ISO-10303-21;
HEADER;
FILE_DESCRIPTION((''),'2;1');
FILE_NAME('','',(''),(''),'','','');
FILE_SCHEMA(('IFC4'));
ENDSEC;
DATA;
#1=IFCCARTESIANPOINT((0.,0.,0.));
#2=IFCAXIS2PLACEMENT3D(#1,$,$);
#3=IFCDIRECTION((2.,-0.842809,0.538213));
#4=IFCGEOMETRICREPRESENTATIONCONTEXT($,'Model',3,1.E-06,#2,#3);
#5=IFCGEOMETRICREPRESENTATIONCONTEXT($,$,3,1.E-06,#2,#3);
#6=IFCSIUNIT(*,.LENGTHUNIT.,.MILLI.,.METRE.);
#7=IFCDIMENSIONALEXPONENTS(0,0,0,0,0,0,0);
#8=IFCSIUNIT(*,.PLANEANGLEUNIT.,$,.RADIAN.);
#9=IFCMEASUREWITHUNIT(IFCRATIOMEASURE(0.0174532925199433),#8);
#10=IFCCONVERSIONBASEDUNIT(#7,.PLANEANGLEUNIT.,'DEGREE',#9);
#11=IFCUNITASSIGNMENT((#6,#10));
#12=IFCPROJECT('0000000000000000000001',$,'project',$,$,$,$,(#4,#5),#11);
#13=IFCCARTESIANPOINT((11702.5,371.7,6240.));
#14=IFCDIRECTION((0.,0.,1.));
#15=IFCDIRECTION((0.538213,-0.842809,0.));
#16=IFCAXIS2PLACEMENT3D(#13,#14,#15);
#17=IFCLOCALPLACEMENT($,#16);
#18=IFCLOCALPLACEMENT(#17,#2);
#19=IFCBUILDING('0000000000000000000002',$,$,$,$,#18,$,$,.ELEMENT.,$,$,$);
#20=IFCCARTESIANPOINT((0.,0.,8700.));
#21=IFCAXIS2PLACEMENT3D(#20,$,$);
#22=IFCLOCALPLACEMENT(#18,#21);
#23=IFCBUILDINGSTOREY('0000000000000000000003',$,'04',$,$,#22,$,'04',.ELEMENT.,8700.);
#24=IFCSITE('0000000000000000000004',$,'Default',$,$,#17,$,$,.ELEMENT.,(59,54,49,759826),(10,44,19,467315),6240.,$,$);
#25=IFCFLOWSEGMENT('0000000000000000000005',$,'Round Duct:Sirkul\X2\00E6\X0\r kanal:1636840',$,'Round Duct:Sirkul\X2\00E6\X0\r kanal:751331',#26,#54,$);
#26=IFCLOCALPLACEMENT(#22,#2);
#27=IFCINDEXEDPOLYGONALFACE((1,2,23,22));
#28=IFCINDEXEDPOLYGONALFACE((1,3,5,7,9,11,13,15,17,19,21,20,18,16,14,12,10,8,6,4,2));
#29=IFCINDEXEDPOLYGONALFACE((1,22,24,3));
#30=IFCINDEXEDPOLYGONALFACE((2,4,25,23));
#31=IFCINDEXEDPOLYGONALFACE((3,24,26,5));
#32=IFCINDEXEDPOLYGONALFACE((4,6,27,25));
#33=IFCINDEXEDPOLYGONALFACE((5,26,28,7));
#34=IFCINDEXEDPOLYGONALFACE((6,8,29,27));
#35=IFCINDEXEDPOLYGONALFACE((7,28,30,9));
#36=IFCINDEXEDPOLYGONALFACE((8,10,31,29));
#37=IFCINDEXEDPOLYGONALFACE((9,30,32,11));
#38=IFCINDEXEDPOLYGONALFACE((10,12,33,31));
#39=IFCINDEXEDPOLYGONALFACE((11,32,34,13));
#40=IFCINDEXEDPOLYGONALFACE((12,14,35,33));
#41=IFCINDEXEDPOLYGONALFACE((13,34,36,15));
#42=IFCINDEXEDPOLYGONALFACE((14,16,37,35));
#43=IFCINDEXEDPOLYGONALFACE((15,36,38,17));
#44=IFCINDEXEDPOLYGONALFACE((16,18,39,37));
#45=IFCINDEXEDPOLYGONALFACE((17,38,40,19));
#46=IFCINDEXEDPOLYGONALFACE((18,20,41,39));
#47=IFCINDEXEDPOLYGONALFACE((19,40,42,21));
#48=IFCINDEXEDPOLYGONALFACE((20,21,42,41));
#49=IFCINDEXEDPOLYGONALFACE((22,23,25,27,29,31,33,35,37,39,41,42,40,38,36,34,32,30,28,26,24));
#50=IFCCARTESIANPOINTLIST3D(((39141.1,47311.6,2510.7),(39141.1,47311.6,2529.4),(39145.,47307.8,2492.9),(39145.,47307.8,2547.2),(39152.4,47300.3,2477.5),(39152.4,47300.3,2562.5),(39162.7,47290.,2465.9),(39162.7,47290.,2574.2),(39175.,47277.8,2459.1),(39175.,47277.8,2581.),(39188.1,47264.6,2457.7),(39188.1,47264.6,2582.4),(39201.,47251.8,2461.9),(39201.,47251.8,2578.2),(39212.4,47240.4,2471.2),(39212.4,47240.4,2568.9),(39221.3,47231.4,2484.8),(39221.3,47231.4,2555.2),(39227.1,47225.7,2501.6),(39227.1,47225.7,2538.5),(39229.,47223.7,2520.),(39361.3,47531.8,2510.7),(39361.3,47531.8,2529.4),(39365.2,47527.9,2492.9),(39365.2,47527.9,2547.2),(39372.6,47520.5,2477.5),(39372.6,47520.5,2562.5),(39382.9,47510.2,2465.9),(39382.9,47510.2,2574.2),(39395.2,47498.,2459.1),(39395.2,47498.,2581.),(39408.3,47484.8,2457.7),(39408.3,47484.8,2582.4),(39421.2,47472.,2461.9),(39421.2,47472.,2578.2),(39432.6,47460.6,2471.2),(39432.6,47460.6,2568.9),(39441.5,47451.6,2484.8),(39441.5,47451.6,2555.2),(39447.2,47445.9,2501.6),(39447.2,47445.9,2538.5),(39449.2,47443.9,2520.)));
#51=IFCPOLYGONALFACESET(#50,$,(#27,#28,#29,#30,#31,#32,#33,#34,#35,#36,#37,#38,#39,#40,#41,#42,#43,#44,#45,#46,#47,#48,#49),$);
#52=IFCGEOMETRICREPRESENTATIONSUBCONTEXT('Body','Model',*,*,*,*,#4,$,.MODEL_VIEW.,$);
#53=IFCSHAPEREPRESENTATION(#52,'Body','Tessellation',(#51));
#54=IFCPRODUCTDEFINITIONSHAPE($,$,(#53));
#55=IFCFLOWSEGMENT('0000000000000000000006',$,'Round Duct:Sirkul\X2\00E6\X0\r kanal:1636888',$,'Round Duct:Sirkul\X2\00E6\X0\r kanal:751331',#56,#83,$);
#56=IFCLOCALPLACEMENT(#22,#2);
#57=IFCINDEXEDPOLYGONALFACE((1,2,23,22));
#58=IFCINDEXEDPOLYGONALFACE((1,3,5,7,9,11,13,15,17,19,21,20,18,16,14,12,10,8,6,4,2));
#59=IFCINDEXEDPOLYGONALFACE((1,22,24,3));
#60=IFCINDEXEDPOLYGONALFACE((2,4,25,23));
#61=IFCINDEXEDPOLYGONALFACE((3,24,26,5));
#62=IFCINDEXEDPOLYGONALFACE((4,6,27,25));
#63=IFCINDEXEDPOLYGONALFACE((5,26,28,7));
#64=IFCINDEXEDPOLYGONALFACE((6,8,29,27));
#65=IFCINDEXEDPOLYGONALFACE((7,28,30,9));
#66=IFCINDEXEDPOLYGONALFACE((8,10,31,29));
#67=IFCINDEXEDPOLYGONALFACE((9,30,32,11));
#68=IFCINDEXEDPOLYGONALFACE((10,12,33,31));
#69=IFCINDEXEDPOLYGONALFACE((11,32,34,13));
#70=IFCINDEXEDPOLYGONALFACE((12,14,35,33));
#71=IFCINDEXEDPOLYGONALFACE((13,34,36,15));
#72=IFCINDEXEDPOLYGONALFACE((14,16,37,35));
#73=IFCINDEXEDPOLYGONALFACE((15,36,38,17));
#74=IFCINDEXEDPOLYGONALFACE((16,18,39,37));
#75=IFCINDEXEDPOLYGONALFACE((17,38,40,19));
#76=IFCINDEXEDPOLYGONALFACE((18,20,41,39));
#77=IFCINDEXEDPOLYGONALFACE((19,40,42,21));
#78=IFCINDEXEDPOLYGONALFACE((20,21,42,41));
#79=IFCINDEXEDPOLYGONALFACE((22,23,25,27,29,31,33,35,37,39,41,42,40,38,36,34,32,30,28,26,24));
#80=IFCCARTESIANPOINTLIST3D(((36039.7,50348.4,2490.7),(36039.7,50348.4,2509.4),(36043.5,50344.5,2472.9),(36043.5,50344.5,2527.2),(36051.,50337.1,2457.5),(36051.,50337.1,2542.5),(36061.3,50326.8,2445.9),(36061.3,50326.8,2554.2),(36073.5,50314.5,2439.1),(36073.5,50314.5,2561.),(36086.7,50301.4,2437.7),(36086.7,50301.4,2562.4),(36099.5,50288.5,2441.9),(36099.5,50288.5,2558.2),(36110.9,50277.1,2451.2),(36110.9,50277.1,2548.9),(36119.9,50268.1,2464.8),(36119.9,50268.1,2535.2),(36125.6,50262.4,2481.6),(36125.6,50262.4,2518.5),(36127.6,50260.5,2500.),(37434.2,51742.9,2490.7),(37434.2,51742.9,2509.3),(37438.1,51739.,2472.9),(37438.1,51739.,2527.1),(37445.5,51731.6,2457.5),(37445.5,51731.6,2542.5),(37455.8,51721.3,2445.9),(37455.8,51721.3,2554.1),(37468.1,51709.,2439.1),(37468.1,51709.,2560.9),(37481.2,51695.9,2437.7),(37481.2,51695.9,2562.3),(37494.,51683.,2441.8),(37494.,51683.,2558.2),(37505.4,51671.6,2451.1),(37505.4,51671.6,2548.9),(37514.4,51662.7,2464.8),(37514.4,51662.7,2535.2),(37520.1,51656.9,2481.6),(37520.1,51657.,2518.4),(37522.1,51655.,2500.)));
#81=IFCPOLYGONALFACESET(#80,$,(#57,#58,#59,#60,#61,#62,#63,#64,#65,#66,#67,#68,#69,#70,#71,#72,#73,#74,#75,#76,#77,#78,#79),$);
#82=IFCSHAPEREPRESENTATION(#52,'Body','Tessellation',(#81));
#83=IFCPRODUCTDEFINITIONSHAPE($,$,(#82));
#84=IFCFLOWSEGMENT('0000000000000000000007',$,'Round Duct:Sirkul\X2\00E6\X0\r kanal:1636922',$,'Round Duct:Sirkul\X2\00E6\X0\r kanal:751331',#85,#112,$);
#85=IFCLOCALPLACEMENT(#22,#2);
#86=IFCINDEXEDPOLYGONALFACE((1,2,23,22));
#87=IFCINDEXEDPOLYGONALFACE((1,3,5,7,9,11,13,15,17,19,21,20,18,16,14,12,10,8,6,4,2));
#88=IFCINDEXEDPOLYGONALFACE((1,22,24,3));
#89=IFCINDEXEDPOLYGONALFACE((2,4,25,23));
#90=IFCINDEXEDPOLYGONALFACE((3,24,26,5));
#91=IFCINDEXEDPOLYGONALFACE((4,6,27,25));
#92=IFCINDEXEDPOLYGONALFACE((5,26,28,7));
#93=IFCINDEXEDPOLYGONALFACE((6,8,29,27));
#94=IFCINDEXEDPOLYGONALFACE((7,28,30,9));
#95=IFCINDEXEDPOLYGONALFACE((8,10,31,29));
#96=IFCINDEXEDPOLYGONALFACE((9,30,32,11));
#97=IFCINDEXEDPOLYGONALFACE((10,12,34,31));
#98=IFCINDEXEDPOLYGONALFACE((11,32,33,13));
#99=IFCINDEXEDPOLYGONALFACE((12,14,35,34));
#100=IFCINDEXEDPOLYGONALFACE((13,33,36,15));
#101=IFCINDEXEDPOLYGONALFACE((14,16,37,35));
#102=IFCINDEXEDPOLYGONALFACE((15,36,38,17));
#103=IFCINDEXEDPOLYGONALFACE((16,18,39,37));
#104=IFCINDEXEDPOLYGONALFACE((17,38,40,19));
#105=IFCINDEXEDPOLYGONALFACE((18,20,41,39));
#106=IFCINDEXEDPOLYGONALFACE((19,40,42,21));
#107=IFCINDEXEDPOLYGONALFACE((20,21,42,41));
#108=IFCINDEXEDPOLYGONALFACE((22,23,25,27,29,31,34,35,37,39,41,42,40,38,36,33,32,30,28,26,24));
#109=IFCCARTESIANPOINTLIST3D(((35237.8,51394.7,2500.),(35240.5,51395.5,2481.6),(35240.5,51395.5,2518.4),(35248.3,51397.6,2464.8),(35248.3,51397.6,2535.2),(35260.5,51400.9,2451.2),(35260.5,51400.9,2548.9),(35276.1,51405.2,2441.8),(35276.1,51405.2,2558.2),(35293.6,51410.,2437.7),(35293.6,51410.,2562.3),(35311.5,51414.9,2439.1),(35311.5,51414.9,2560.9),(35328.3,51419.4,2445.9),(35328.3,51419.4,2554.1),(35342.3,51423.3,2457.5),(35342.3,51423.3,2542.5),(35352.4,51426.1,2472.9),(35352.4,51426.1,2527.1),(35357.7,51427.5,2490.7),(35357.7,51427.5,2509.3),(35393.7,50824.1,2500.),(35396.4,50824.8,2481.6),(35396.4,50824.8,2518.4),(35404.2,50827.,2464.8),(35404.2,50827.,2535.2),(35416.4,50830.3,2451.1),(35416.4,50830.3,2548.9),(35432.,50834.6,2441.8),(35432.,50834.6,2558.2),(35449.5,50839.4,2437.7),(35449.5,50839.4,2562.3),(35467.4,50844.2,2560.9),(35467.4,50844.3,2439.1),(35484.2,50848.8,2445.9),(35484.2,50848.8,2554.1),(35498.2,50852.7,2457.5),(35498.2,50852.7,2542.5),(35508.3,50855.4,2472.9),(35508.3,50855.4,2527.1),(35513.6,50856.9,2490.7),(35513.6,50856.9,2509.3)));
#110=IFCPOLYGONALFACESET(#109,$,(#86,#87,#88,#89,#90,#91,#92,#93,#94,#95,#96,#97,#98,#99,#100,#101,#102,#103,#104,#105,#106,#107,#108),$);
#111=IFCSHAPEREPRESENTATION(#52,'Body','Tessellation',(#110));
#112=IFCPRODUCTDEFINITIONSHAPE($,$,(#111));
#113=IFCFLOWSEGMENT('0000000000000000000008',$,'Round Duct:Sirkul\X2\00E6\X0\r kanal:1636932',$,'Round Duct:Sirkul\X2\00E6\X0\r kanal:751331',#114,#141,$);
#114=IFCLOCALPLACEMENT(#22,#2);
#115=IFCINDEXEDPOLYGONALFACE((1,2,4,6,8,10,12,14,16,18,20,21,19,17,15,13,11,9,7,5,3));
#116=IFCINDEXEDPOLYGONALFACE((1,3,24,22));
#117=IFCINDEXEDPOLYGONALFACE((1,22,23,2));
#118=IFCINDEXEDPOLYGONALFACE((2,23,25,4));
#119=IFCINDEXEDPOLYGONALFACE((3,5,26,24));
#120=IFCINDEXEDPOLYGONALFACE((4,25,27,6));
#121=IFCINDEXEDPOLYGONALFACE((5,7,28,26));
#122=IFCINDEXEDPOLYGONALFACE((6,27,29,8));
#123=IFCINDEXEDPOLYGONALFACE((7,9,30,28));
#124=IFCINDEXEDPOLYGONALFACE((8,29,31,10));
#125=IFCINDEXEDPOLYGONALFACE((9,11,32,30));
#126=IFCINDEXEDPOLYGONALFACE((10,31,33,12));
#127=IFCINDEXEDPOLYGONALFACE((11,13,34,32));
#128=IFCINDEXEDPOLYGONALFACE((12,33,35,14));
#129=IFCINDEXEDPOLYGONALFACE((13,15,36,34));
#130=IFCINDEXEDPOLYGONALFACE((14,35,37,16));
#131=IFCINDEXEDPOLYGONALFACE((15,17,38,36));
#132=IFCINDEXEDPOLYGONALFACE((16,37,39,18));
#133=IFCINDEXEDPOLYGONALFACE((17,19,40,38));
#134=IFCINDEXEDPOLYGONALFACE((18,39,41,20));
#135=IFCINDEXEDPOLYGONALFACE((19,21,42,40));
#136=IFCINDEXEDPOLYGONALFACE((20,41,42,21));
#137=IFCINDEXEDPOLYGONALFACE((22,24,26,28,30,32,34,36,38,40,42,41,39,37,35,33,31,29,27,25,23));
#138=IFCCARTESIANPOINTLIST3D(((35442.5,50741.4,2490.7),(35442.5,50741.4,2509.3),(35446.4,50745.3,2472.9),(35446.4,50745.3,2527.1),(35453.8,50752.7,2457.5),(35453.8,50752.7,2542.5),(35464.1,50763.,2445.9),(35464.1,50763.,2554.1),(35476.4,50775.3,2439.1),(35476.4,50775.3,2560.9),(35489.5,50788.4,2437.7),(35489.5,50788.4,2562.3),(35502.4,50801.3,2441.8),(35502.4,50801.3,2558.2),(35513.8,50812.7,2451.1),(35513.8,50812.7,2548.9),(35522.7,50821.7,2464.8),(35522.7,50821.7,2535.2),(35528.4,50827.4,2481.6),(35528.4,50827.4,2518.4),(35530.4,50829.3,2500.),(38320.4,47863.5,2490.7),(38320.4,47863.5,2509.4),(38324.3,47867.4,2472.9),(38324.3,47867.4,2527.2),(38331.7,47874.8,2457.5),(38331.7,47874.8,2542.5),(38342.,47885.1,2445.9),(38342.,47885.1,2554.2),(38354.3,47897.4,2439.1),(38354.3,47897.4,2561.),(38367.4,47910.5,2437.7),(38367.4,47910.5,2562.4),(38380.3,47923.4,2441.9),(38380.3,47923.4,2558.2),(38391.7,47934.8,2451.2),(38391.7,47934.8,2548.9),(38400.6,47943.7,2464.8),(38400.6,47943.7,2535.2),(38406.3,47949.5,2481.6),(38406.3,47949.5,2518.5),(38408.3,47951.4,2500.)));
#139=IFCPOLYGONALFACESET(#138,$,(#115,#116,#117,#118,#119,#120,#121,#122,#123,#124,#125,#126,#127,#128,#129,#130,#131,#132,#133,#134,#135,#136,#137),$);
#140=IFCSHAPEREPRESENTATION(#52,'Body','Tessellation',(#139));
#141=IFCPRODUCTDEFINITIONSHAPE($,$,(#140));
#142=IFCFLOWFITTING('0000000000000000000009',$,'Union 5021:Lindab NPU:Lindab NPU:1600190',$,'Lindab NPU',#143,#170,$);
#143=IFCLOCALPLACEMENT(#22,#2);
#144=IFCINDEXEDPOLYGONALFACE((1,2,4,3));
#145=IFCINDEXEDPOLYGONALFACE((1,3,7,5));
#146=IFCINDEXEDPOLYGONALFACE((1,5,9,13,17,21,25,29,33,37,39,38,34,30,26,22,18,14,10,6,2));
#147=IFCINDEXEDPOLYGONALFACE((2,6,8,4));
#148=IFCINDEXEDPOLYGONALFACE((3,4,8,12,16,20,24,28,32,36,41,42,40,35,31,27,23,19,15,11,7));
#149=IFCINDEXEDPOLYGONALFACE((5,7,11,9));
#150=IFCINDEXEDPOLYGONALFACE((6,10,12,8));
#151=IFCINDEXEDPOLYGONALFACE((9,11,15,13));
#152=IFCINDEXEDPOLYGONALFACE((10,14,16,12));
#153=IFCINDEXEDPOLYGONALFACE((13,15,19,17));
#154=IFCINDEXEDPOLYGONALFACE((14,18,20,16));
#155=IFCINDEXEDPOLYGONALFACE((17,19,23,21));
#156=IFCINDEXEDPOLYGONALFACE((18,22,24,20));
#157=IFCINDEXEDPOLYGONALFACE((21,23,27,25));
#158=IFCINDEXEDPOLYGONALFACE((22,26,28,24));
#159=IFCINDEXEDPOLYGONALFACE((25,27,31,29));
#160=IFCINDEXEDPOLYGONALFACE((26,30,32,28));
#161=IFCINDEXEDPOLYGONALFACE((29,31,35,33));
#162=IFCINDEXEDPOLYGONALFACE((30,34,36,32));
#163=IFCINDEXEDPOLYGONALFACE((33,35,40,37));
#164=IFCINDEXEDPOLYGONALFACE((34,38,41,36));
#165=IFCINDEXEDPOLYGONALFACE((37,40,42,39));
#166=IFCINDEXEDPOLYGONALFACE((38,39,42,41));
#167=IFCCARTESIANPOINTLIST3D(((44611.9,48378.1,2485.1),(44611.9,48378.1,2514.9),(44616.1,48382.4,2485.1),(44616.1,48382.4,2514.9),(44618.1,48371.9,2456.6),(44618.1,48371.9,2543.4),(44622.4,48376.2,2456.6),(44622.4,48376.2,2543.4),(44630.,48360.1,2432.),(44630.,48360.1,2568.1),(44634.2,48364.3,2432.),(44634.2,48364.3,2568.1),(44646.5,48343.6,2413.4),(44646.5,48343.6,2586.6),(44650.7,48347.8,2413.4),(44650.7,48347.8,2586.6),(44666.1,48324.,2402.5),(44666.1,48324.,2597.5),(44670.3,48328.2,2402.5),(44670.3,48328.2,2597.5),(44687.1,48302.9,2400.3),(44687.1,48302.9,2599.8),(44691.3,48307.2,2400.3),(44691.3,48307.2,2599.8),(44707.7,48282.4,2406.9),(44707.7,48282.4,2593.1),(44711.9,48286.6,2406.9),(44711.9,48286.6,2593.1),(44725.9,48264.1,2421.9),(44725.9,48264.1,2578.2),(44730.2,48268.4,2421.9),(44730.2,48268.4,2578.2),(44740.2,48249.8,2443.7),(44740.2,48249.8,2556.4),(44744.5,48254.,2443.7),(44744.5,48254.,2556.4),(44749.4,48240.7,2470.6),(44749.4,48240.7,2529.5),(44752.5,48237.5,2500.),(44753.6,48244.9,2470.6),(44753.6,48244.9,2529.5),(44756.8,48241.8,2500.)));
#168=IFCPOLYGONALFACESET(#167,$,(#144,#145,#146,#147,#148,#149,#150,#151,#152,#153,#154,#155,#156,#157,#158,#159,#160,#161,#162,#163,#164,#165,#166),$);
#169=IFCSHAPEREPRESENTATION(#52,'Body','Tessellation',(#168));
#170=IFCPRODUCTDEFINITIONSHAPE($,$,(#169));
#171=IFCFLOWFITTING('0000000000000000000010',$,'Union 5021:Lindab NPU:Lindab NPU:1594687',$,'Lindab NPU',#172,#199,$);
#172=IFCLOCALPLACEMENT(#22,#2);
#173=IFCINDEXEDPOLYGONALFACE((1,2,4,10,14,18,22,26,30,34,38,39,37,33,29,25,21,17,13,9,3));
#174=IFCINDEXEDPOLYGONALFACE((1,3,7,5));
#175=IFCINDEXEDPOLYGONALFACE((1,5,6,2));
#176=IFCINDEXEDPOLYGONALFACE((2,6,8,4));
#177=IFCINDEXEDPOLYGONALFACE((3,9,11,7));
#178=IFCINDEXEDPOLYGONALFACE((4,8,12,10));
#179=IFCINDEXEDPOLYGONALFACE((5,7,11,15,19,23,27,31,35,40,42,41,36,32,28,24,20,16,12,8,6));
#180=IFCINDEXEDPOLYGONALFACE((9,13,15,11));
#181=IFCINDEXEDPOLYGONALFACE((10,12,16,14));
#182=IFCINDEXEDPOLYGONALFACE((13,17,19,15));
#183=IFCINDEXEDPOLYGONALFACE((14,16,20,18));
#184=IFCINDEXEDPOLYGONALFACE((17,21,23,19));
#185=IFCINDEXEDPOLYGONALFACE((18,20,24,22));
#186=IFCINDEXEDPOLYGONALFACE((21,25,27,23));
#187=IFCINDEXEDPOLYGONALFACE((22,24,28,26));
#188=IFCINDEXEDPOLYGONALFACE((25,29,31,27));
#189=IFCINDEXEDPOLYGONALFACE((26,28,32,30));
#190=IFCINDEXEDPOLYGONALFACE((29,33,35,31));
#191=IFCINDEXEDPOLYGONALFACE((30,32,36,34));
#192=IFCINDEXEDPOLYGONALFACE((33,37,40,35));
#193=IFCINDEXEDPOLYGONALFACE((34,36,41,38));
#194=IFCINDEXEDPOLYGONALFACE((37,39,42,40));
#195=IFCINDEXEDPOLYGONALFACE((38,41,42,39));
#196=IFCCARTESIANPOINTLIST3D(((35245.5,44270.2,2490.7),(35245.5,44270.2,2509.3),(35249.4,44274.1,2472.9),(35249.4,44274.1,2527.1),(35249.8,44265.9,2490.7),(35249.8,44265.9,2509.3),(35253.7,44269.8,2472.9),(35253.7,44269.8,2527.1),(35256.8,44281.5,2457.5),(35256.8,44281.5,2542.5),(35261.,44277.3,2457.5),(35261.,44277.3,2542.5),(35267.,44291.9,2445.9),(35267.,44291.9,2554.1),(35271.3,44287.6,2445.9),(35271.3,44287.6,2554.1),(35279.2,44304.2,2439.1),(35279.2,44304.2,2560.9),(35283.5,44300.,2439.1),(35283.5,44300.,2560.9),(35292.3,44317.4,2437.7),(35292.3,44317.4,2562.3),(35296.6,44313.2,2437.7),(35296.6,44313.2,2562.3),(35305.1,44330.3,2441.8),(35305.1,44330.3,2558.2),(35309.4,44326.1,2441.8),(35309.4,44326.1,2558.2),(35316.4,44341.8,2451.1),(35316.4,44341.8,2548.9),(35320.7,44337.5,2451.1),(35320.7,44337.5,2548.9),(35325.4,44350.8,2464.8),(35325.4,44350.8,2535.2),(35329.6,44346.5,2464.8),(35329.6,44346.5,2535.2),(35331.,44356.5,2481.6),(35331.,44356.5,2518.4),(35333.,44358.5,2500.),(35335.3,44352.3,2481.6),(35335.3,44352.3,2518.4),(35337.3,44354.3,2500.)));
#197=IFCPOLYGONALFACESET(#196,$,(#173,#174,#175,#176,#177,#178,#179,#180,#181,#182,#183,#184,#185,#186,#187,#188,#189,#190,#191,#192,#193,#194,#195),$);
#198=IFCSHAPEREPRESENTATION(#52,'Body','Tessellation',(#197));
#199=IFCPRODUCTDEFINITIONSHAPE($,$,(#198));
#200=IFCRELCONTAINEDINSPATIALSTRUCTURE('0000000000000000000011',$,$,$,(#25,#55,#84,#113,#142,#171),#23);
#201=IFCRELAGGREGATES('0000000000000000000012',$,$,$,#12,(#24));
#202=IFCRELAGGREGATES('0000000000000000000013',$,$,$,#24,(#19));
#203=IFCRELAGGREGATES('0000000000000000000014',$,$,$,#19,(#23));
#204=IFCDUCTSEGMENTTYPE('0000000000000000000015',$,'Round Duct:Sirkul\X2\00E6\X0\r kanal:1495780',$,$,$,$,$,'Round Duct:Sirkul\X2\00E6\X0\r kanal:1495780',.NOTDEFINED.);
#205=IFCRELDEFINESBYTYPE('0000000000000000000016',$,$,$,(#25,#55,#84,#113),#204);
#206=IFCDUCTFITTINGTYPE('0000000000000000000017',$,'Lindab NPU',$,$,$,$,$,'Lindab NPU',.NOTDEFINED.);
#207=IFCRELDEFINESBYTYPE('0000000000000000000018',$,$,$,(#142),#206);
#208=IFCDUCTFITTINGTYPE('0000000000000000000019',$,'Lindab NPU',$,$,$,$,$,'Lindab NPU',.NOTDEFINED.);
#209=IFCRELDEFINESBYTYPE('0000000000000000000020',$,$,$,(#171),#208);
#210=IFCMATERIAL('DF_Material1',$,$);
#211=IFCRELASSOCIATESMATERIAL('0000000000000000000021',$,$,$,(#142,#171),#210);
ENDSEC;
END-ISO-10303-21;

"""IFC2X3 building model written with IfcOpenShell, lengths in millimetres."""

from ifc_helpers import new_model, entity, si_unit, converted_unit, direction, frame, frame_2d, origin, origin_2d_with_axis, place, context, subcontext, project, spatial, circle, extrude, source, transform, mapped, material, type_object, type_shapes, element, save


model = new_model("IFC2X3")

# Units and contexts
model_context = context("Model", 3, precision=1e-06, world=origin(), true_north=direction((2.0, -0.842809, 0.538213)))
context_of_model = context(None, 3, precision=1e-06, world=origin(), true_north=direction((2.0, -0.842809, 0.538213)))
body_context = subcontext(model_context, "Body", "Model", "MODEL_VIEW")
ifc_project = project(units=[si_unit("LENGTHUNIT", "METRE", prefix="MILLI"), converted_unit("PLANEANGLEUNIT", "DEGREE", entity("IfcRatioMeasure", 0.0174532925199433), si_unit("PLANEANGLEUNIT", "RADIAN"), dimensions=[0, 0, 0, 0, 0, 0, 0])], contexts=[model_context, context_of_model])

# Site, building, storey
site_placement = place(None, frame((11702.5, 371.7, 6240.0), z_axis=(0.0, 0.0, 1.0), x_axis=(0.538213, -0.842809, 0.0)))
site = spatial("IfcSite", under=ifc_project, at=site_placement, Name="Default", CompositionType="ELEMENT", RefLatitude=(59, 54, 49, 759826), RefLongitude=(10, 44, 19, 467315), RefElevation=6240.0)
building_placement = place(site_placement, origin())
building = spatial("IfcBuilding", under=site, at=building_placement, CompositionType="ELEMENT")
storey_placement = place(building_placement, frame((0.0, 0.0, 8700.0)))
storey = spatial("IfcBuildingStorey", under=building, at=storey_placement, Name="04", LongName="04", CompositionType="ELEMENT", Elevation=8700.0)

# Flow segments
duct_segment_type = type_object("IfcDuctSegmentType", Name="Round Duct:Sirkulær kanal:1495780", ElementType="Round Duct:Sirkulær kanal:1495780", PredefinedType="NOTDEFINED")
flow_segment_1_placement = place(storey_placement, origin())
element("IfcFlowSegment", 1, at=flow_segment_1_placement, inside=storey, type_object=duct_segment_type, Name="Round Duct:Sirkulær kanal:1636840", ObjectType="Round Duct:Sirkulær kanal:751331", context=body_context, shape_type="SweptSolid", body=[
    extrude(circle(Radius=62.5, at=origin_2d_with_axis()), frame((39184.8, 47267.9, 2520.0), z_axis=(0.707107, 0.707107, 0.0), x_axis=(0.707107, -0.707107, 0.0)), (0.0, 0.0, 1.0), 311.4),
])
flow_segment_2_placement = place(storey_placement, origin())
element("IfcFlowSegment", 2, at=flow_segment_2_placement, inside=storey, type_object=duct_segment_type, Name="Round Duct:Sirkulær kanal:1636888", ObjectType="Round Duct:Sirkulær kanal:751331", context=body_context, shape_type="SweptSolid", body=[
    extrude(circle(Radius=62.5, at=origin_2d_with_axis()), frame((36083.4, 50304.7, 2500.0), z_axis=(0.707107, 0.707107, -0.000017), x_axis=(0.707107, -0.707107, 0.0)), (0.0, 0.0, 1.0), 1972.2),
])
flow_segment_3_placement = place(storey_placement, origin())
element("IfcFlowSegment", 3, at=flow_segment_3_placement, inside=storey, type_object=duct_segment_type, Name="Round Duct:Sirkulær kanal:1636922", ObjectType="Round Duct:Sirkulær kanal:751331", context=body_context, shape_type="SweptSolid", body=[
    extrude(circle(Radius=62.5, at=origin_2d_with_axis()), frame((35298.1, 51411.2, 2500.0), z_axis=(0.263536, -0.964649, -0.000027), x_axis=(-0.964649, -0.263536, 0.0)), (0.0, 0.0, 1.0), 591.5),
])
flow_segment_4_placement = place(storey_placement, origin())
element("IfcFlowSegment", 4, at=flow_segment_4_placement, inside=storey, type_object=duct_segment_type, Name="Round Duct:Sirkulær kanal:1636932", ObjectType="Round Duct:Sirkulær kanal:751331", context=body_context, shape_type="SweptSolid", body=[
    extrude(circle(Radius=62.5, at=frame_2d((0.0, 0.0), x_axis=(1.0, 0.0))), frame((35486.2, 50785.1, 2500.0), z_axis=(0.707107, -0.707107, 0.000009), x_axis=(0.707107, 0.707107, 0.0)), (0.0, 0.0, 1.0), 4070.0),
])

# Flow fittings
ifc_material = material(Name="DF_Material1")
duct_fitting_type_1 = type_object("IfcDuctFittingType", Name="Lindab NPU", ElementType="Lindab NPU", PredefinedType="NOTDEFINED")
shared_shape_1 = source(origin(), body_context, "Body", "SweptSolid", [
    extrude(circle(Radius=100.0, at=frame_2d((0.0, 0.0), x_axis=(1.0, 0.0))), frame((0.0, 0.0, 0.0), z_axis=(1.0, 0.0, 0.0), x_axis=(0.0, 1.0, 0.0)), (0.0, 0.0, 1.0), 6.0),
])
type_shapes(duct_fitting_type_1, [shared_shape_1])
flow_fitting_1_placement = place(building_placement, frame((44686.1, 48312.5, 11200.0), z_axis=(0.0, 0.0, 1.0), x_axis=(-0.707107, -0.707107, 0.0)))
element("IfcFlowFitting", 5, at=flow_fitting_1_placement, inside=storey, type_object=duct_fitting_type_1, material=ifc_material, Name="Union 5021:Lindab NPU:Lindab NPU:1600190", ObjectType="Lindab NPU", context=body_context, shape_type="MappedRepresentation", body=[
    mapped(shared_shape_1, transform((0.0, 0.0, 0.0), scale=1.0)),
])
duct_fitting_type_2 = type_object("IfcDuctFittingType", Name="Lindab NPU", ElementType="Lindab NPU", PredefinedType="NOTDEFINED")
shared_shape_2 = source(origin(), body_context, "Body", "SweptSolid", [
    extrude(circle(Radius=62.5, at=frame_2d((0.0, 0.0), x_axis=(1.0, 0.0))), frame((0.0, 0.0, 0.0), z_axis=(1.0, 0.0, 0.0), x_axis=(0.0, 1.0, 0.0)), (0.0, 0.0, 1.0), 6.0),
])
type_shapes(duct_fitting_type_2, [shared_shape_2])
for number, where, z_axis, x_axis, name in (
    (6, (35289.0, 44314.1, 11200.0), (0.0, 0.0, 1.0), (0.710554, -0.703643, 0.0), "Union 5021:Lindab NPU:Lindab NPU:1594687"),
):
    element("IfcFlowFitting", number, at=place(building_placement, frame(where, z_axis=z_axis, x_axis=x_axis)), inside=storey, type_object=duct_fitting_type_2, material=ifc_material, Name=name, ObjectType="Lindab NPU", context=body_context, shape_type="MappedRepresentation", body=[
        mapped(shared_shape_2, transform((0.0, 0.0, 0.0), scale=1.0)),
    ])

save(model, "model.ifc")
